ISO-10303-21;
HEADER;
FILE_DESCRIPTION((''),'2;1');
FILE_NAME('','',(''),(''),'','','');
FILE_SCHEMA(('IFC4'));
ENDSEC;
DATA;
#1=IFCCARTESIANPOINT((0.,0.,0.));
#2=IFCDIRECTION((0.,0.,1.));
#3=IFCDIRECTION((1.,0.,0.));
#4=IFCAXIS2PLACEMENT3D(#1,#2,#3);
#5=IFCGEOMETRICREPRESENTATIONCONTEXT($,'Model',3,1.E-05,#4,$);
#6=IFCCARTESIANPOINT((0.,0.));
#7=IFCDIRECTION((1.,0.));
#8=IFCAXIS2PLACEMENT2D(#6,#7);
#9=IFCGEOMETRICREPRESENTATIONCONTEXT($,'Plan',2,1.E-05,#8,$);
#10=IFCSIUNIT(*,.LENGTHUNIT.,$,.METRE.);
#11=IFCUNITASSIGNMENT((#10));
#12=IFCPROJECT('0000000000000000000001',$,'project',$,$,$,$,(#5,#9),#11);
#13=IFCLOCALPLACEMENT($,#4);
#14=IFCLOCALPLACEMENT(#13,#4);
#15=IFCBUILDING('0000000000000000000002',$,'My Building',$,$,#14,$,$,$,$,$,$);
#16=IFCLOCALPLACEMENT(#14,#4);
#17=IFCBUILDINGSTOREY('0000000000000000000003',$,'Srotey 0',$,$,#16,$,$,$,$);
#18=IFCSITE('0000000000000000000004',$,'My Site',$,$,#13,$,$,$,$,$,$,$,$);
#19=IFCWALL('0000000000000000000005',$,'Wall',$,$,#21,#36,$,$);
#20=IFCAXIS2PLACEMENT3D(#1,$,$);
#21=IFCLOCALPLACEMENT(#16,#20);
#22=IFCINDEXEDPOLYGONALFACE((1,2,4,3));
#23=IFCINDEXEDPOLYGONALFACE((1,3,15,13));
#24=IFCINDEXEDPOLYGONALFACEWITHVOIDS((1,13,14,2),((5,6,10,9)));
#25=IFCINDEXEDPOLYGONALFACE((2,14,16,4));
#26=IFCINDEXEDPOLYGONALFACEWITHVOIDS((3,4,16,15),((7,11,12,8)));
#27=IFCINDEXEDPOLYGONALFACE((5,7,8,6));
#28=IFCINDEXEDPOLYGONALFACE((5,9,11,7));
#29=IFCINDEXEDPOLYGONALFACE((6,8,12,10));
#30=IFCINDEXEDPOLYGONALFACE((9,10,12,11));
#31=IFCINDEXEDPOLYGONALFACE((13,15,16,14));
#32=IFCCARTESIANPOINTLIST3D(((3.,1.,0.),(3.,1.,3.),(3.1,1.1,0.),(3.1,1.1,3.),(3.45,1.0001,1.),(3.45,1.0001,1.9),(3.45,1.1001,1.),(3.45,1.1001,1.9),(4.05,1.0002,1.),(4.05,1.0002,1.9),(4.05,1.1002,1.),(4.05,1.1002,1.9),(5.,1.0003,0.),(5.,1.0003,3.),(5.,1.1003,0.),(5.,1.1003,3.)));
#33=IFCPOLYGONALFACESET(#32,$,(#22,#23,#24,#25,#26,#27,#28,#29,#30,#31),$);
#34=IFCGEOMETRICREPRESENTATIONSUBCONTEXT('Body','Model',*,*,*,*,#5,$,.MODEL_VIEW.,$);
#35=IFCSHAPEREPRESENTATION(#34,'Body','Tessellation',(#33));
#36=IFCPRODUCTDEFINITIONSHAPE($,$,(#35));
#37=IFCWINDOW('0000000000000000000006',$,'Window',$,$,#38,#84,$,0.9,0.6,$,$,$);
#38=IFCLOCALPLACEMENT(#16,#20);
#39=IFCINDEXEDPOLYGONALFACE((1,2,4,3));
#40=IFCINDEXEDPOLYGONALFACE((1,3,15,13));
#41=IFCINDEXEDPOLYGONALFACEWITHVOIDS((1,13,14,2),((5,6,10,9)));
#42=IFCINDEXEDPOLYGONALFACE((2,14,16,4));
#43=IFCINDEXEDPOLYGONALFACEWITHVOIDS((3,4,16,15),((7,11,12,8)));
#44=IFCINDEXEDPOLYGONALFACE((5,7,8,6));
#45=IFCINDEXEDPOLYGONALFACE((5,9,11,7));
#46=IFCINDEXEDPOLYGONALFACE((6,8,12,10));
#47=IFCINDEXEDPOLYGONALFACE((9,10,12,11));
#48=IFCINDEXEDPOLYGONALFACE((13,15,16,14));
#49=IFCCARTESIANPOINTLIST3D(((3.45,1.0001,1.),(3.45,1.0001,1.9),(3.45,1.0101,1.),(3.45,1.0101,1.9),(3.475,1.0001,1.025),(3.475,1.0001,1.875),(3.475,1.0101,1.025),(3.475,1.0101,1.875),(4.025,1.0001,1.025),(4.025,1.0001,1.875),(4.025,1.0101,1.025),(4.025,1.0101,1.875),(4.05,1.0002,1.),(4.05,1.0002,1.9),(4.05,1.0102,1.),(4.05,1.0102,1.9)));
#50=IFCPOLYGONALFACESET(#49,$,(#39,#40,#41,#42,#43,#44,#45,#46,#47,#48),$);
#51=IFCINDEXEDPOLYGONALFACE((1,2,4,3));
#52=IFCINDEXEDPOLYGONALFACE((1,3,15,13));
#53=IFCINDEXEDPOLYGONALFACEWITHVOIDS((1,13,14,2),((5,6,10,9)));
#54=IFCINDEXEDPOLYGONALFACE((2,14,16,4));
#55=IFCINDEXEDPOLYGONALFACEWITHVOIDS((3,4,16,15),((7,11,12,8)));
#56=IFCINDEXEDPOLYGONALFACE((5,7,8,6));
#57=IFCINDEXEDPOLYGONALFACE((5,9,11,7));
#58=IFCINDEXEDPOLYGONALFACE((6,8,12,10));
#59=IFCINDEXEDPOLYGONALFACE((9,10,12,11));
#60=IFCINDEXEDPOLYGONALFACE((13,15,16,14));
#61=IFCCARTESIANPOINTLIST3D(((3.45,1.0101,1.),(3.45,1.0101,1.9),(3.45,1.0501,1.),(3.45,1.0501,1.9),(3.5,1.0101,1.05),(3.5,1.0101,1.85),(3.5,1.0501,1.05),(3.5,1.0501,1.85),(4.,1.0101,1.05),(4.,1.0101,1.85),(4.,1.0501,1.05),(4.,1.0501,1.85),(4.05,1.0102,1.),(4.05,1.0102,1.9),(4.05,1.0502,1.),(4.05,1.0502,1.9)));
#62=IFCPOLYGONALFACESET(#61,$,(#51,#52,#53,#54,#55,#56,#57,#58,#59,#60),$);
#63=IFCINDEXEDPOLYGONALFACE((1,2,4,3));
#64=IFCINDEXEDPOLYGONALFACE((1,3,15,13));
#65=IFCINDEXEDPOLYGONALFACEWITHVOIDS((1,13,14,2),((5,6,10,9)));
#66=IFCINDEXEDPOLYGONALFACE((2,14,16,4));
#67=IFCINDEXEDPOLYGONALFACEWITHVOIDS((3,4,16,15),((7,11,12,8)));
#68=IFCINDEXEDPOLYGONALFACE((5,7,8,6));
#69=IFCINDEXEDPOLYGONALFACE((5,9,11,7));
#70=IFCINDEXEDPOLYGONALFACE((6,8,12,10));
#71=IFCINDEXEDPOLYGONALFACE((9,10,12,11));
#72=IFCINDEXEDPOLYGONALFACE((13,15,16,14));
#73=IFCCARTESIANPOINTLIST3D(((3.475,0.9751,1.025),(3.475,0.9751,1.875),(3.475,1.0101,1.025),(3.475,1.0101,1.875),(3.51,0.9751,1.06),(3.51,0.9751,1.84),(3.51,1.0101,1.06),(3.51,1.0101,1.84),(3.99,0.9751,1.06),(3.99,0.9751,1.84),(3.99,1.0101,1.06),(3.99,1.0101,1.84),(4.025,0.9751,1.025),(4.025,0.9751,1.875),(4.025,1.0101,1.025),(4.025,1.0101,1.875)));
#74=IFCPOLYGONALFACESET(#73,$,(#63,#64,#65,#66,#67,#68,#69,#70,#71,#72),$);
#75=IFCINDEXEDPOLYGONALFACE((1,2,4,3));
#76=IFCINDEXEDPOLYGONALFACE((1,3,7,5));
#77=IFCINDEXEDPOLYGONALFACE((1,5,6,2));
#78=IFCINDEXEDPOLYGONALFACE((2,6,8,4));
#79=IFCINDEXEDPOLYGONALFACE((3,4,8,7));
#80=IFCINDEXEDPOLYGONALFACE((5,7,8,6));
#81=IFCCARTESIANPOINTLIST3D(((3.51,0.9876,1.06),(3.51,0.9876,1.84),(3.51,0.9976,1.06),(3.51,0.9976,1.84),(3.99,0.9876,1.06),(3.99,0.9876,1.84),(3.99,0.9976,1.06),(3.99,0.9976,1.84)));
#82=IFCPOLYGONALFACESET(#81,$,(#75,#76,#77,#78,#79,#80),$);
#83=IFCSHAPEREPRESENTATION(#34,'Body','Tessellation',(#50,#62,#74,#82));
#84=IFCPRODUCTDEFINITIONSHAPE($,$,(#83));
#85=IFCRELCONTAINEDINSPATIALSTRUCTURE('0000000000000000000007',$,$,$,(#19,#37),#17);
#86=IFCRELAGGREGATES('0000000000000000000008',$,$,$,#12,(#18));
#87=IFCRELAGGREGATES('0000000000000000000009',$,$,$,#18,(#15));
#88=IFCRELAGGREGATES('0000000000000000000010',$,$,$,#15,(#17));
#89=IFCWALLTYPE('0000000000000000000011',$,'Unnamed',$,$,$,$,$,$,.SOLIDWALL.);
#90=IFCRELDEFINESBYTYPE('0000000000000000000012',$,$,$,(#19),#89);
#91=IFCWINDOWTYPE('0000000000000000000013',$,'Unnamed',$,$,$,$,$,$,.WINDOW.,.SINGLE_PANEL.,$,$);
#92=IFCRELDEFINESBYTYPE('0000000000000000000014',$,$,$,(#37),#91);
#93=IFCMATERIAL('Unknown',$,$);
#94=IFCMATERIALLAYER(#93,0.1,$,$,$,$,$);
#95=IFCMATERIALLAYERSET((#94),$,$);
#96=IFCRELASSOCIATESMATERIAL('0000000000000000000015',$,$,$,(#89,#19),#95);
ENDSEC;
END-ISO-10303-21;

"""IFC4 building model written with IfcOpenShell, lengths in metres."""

from ifc_helpers import new_model, entity, si_unit, frame, origin_with_axes, origin_2d_with_axis, place, context, subcontext, project, spatial, line, indexed_curve, outline, extrude, shape, source, transform, mapped, material, layer, layer_set, layer_usage, type_object, type_shapes, element, fill, save


model = new_model("IFC4")

# Units and contexts
model_context = context("Model", 3, precision=1e-05, world=origin_with_axes())
plan_context = context("Plan", 2, precision=1e-05, world=origin_2d_with_axis())
body_context_1 = subcontext(model_context, "Body", "Model", "MODEL_VIEW")
body_context_2 = subcontext(plan_context, "Body", "Plan", "PLAN_VIEW")
ifc_project = project(units=[si_unit("LENGTHUNIT", "METRE")], contexts=[model_context, plan_context])

# Site, building, storey
site_placement = place(None, origin_with_axes())
site = spatial("IfcSite", under=ifc_project, at=site_placement, Name="My Site")
building_placement = place(site_placement, origin_with_axes())
building = spatial("IfcBuilding", under=site, at=building_placement, Name="My Building")
storey_placement = place(building_placement, origin_with_axes())
storey = spatial("IfcBuildingStorey", under=building, at=storey_placement, Name="Srotey 0")

# Shared definitions
ifc_material = material(Name="Unknown")
ifc_layer = layer(ifc_material, 0.1)
ifc_layer_set = layer_set([ifc_layer])
wall_type = type_object("IfcWallType", Name="Unnamed", PredefinedType="SOLIDWALL", material=ifc_layer_set)

# Shared definitions
shared_shape_1 = source(origin_with_axes(), body_context_1, "Body", "SweptSolid", [
    extrude(outline(indexed_curve([(0.0, 0.0), (0.6, 0.0), (0.6, 0.9), (0.0, 0.9)], segments=[line(1, 2, 3, 4, 1)])), frame((0.0, -0.6, 0.0), z_axis=(0.0, -1.0, 0.0), x_axis=(1.0, 0.0, 0.0)), (0.0, 0.0, -1.0), 1.2),
])
window_type = type_object("IfcWindowType", Name="Unnamed", PartitioningType="SINGLE_PANEL", PredefinedType="WINDOW")
shared_shape_2 = source(origin_with_axes(), body_context_1, "Body", "SweptSolid", [
    extrude(outline(indexed_curve([(0.0, 0.0), (0.6, 0.0), (0.6, 0.9), (0.0, 0.9)], segments=[line(1, 2, 3, 4, 1)]), holes=[indexed_curve([(0.025, 0.025), (0.575, 0.025), (0.575, 0.875), (0.025, 0.875)], segments=[line(1, 2, 3, 4, 1)])]), frame((0.0, 0.09, 0.0), z_axis=(0.0, -1.0, 0.0), x_axis=(1.0, 0.0, 0.0)), (0.0, 0.0, -1.0), 0.01),
    extrude(outline(indexed_curve([(0.0, 0.0), (0.6, 0.0), (0.6, 0.9), (0.0, 0.9)], segments=[line(1, 2, 3, 4, 1)]), holes=[indexed_curve([(0.05, 0.05), (0.55, 0.05), (0.55, 0.85), (0.05, 0.85)], segments=[line(1, 2, 3, 4, 1)])]), frame((0.0, 0.05, 0.0), z_axis=(0.0, -1.0, 0.0), x_axis=(1.0, 0.0, 0.0)), (0.0, 0.0, -1.0), 0.04),
    extrude(outline(indexed_curve([(0.0, 0.0), (0.55, 0.0), (0.55, 0.85), (0.0, 0.85)], segments=[line(1, 2, 3, 4, 1)]), holes=[indexed_curve([(0.035, 0.035), (0.515, 0.035), (0.515, 0.815), (0.035, 0.815)], segments=[line(1, 2, 3, 4, 1)])]), frame((0.025, 0.09, 0.025), z_axis=(0.0, -1.0, 0.0), x_axis=(1.0, 0.0, 0.0)), (0.0, 0.0, -1.0), 0.035),
    extrude(outline(indexed_curve([(0.035, 0.035), (0.515, 0.035), (0.515, 0.815), (0.035, 0.815)], segments=[line(1, 2, 3, 4, 1)])), frame((0.025, 0.1025, 0.025), z_axis=(0.0, -1.0, 0.0), x_axis=(1.0, 0.0, 0.0)), (0.0, 0.0, -1.0), 0.01),
])
shared_shape_3 = source(origin_with_axes(), body_context_2, "Body", "Curve2D", [
    entity("IfcIndexedPolyCurve", entity("IfcCartesianPointList2D", [[0.05, 0.05], [0.55, 0.05]])),
    entity("IfcIndexedPolyCurve", entity("IfcCartesianPointList2D", [[0.0, 0.1], [0.025, 0.1], [0.025, 0.09], [0.05, 0.09], [0.05, 0.05], [0.0, 0.05]]), [entity("IfcLineIndex", [1, 2, 3, 4, 5, 6, 1])]),
    entity("IfcIndexedPolyCurve", entity("IfcCartesianPointList2D", [[0.6, 0.1], [0.575, 0.1], [0.575, 0.09], [0.55, 0.09], [0.55, 0.05], [0.6, 0.05]]), [entity("IfcLineIndex", [1, 2, 3, 4, 5, 6, 1])]),
    entity("IfcIndexedPolyCurve", entity("IfcCartesianPointList2D", [[0.025, 0.09], [0.06, 0.09], [0.06, 0.125], [0.025, 0.125]]), [entity("IfcLineIndex", [1, 2, 3, 4, 1])]),
    entity("IfcIndexedPolyCurve", entity("IfcCartesianPointList2D", [[0.575, 0.09], [0.54, 0.09], [0.54, 0.125], [0.575, 0.125]]), [entity("IfcLineIndex", [1, 2, 3, 4, 1])]),
    entity("IfcIndexedPolyCurve", entity("IfcCartesianPointList2D", [[0.06, 0.09], [0.54, 0.09]])),
    entity("IfcIndexedPolyCurve", entity("IfcCartesianPointList2D", [[0.06, 0.125], [0.54, 0.125]])),
    entity("IfcIndexedPolyCurve", entity("IfcCartesianPointList2D", [[0.06, 0.1075], [0.54, 0.1075]])),
])
type_shapes(window_type, [shared_shape_2, shared_shape_3])

# Wall, opening, window
ifc_layer_usage_1 = layer_usage(ifc_layer_set, "AXIS2", "POSITIVE", 0.0)
wall_1_placement = place(storey_placement, frame((3.0, 1.0, 0.0), z_axis=(0.0, 0.0, 1.0), x_axis=(1.0, 0.000144, 0.0)))
wall_1 = element("IfcWall", 1, at=wall_1_placement, inside=storey, type_object=wall_type, material=ifc_layer_usage_1, Name="Wall", context=body_context_1, shape_type="SweptSolid", body=[
    extrude(outline(indexed_curve([(0.0, 0.0), (0.1, 0.1), (2.0, 0.1), (2.0, 0.0)], segments=[line(1, 2, 3, 4, 1)])), origin_with_axes(), (0.0, 0.0, 1.0), 3.0),
])
opening_1_placement = place(wall_1_placement, frame((1.05, 0.1, 1.0), z_axis=(0.0, 0.0, 1.0), x_axis=(-1.0, 0.0, 0.0)))
opening_1 = element("IfcOpeningElement", 2, at=opening_1_placement, cuts=wall_1, PredefinedType="OPENING", context=body_context_1, shape_type="MappedRepresentation", body=[
    mapped(shared_shape_1, transform((0.0, 0.0, 0.0), x_axis=(1.0, 0.0, 0.0), y_axis=(0.0, 1.0, 0.0), z_axis=(0.0, 0.0, 1.0), scale=1.0)),
])
window_1_placement = place(opening_1_placement, frame((0.0, 0.0, 0.0), z_axis=(0.0, 0.0, 1.0), x_axis=(1.0, 0.0, 0.0)))
window_1 = element("IfcWindow", 3, at=window_1_placement, inside=storey, type_object=window_type, Name="Window", OverallHeight=0.9, OverallWidth=0.6, shapes=[
    shape(body_context_1, "Body", "MappedRepresentation", [mapped(shared_shape_2, transform((0.0, 0.0, 0.0), x_axis=(1.0, 0.0, 0.0), y_axis=(0.0, 1.0, 0.0), z_axis=(0.0, 0.0, 1.0), scale=1.0))]),
    shape(body_context_2, "Body", "MappedRepresentation", [mapped(shared_shape_3, transform((0.0, 0.0, 0.0), x_axis=(1.0, 0.0, 0.0), y_axis=(0.0, 1.0, 0.0), z_axis=(0.0, 0.0, 1.0), scale=1.0))]),
])
fill(opening_1, window_1)

save(model, "model.ifc")
